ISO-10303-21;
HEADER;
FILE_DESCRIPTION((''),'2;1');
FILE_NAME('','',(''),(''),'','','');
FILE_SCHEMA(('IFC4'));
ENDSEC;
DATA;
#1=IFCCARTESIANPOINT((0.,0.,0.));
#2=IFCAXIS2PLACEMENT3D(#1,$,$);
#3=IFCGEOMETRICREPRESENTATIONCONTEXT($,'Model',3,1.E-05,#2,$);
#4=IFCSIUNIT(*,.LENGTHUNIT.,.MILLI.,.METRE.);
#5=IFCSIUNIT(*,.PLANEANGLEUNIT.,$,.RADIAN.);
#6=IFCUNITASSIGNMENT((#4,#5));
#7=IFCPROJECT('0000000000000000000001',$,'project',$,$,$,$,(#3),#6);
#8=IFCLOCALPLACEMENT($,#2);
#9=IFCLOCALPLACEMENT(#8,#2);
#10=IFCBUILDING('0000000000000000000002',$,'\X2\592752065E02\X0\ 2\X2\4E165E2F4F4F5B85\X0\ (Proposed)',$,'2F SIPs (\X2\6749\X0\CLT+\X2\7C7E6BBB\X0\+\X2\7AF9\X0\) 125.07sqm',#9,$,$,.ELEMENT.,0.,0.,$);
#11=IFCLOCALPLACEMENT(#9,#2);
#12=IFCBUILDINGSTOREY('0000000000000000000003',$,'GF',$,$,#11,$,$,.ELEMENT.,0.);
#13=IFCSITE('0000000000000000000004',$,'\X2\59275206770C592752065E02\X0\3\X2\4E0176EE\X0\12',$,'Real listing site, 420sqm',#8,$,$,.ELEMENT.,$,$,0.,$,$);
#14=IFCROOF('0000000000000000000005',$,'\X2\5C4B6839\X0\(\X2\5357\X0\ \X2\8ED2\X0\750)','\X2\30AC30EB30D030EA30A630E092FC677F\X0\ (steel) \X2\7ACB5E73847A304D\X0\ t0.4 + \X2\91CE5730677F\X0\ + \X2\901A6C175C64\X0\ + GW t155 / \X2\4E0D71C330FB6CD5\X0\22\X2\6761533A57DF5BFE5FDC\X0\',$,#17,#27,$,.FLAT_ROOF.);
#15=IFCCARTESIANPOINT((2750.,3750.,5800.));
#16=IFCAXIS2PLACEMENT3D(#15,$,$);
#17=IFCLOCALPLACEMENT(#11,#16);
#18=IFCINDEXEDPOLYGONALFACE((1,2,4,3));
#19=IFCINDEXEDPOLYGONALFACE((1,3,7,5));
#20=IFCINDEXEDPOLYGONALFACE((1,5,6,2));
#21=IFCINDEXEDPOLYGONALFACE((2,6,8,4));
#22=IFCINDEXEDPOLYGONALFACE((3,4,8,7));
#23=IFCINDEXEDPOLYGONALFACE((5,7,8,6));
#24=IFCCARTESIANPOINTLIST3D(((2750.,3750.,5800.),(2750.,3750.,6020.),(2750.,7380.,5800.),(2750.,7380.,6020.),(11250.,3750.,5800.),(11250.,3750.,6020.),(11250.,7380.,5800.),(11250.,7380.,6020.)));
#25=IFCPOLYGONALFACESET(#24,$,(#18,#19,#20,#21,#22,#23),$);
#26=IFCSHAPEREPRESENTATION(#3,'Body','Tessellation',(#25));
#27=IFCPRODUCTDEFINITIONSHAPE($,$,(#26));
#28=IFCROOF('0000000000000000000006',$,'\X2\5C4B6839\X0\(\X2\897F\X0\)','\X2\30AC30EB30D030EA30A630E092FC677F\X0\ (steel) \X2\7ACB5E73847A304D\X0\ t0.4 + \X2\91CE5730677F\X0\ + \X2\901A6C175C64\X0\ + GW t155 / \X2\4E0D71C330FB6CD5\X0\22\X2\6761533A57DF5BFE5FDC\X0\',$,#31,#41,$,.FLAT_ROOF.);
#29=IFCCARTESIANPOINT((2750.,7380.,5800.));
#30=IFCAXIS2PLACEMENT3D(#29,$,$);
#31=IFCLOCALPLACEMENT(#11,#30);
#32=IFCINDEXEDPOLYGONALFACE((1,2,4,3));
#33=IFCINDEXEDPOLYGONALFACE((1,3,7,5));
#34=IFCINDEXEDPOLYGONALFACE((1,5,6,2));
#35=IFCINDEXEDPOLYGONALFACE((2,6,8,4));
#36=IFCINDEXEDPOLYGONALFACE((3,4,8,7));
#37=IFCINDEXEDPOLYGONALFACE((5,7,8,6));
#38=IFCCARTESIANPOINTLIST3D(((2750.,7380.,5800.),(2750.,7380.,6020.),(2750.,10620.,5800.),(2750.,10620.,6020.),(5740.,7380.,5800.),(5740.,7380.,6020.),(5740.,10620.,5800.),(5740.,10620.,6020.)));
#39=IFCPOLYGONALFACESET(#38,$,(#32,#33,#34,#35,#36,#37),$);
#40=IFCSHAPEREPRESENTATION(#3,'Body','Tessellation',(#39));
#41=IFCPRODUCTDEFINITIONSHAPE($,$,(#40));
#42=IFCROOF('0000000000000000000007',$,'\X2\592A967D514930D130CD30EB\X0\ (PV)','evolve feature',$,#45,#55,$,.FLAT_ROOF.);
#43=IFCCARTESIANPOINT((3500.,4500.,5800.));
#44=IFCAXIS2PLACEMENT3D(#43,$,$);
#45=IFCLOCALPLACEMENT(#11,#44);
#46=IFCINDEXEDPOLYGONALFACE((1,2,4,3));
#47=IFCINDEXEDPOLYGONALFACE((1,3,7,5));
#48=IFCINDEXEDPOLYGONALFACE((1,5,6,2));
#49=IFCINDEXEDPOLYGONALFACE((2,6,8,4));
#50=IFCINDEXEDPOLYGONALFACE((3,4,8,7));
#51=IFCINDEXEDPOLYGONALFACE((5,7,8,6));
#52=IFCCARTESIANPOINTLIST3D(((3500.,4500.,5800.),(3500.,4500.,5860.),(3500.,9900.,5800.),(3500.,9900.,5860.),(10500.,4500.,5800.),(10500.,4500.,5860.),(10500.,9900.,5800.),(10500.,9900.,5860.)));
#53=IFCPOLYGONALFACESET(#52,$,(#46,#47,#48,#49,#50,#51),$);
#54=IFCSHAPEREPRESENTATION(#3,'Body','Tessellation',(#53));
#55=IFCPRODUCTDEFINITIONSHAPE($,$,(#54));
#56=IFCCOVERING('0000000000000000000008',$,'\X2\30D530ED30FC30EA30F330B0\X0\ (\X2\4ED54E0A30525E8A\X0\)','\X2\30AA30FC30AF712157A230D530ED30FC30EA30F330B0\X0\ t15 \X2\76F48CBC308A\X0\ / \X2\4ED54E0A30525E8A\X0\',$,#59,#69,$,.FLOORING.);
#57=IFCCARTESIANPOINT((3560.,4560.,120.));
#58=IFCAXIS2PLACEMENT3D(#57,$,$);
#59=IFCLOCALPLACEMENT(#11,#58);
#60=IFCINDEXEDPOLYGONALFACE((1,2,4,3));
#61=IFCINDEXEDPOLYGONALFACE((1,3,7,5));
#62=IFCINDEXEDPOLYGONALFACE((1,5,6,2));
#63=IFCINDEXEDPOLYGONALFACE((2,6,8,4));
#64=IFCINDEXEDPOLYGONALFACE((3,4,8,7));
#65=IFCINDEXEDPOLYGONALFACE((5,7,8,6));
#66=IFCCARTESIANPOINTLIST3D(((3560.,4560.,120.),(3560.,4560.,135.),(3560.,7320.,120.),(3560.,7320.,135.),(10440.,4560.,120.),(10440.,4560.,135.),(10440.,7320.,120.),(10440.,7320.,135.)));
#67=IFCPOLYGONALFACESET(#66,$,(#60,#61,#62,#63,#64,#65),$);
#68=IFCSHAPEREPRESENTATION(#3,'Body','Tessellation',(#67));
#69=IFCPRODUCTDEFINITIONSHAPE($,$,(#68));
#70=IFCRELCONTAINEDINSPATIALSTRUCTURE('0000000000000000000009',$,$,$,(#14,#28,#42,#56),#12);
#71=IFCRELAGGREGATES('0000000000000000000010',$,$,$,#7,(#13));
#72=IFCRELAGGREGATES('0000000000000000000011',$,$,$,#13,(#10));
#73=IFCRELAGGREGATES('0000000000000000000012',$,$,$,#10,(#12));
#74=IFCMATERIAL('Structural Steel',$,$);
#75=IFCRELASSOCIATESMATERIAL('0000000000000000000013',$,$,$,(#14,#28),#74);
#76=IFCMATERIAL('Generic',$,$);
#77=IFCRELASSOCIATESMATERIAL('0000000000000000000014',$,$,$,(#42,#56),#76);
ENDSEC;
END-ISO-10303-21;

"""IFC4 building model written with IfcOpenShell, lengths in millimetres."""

from ifc_helpers import new_model, si_unit, frame, frame_2d, origin, place, context, project, spatial, rectangle, extrude, material, element, save


model = new_model("IFC4")

# Units and contexts
model_context = context("Model", 3, precision=1e-05, world=origin())
ifc_project = project(units=[si_unit("LENGTHUNIT", "METRE", prefix="MILLI"), si_unit("PLANEANGLEUNIT", "RADIAN")], contexts=[model_context])

# Site, building, storey
site_placement = place(None, origin())
site = spatial("IfcSite", under=ifc_project, at=site_placement, Name="大分県大分市3丁目12", ObjectType="Real listing site, 420sqm", CompositionType="ELEMENT", RefElevation=0.0)
building_placement = place(site_placement, origin())
building = spatial("IfcBuilding", under=site, at=building_placement, Name="大分市 2世帯住宅 (Proposed)", ObjectType="2F SIPs (杉CLT+籾殻+竹) 125.07sqm", CompositionType="ELEMENT", ElevationOfRefHeight=0.0, ElevationOfTerrain=0.0)
storey_placement = place(building_placement, origin())
storey = spatial("IfcBuildingStorey", under=building, at=storey_placement, Name="GF", CompositionType="ELEMENT", Elevation=0.0)

# Shared definitions
ifc_material_1 = material(Name="Generic")

# Roofs
ifc_material_2 = material(Name="Structural Steel")
roof_1_placement = place(storey_placement, frame((2750.0, 3750.0, 5800.0)))
element("IfcRoof", 1, at=roof_1_placement, inside=storey, material=ifc_material_2, Name="屋根(南 軒750)", Description="ガルバリウム鋼板 (steel) 立平葺き t0.4 + 野地板 + 通気層 + GW t155 / 不燃・法22条区域対応", PredefinedType="FLAT_ROOF", context=model_context, shape_type="SweptSolid", body=[
    extrude(rectangle(XDim=8500.0, YDim=3630.0, at=frame_2d((4250.0, 1815.0))), frame((2750.0, 3750.0, 5800.0)), (0.0, 0.0, 1.0), 220.0),
])
roof_2_placement = place(storey_placement, frame((2750.0, 7380.0, 5800.0)))
element("IfcRoof", 2, at=roof_2_placement, inside=storey, material=ifc_material_2, Name="屋根(西)", Description="ガルバリウム鋼板 (steel) 立平葺き t0.4 + 野地板 + 通気層 + GW t155 / 不燃・法22条区域対応", PredefinedType="FLAT_ROOF", context=model_context, shape_type="SweptSolid", body=[
    extrude(rectangle(XDim=2990.0, YDim=3240.0, at=frame_2d((1495.0, 1620.0))), frame((2750.0, 7380.0, 5800.0)), (0.0, 0.0, 1.0), 220.0),
])
roof_3_placement = place(storey_placement, frame((3500.0, 4500.0, 5800.0)))
element("IfcRoof", 3, at=roof_3_placement, inside=storey, material=ifc_material_1, Name="太陽光パネル (PV)", Description="evolve feature", PredefinedType="FLAT_ROOF", context=model_context, shape_type="SweptSolid", body=[
    extrude(rectangle(XDim=7000.0, YDim=5400.0, at=frame_2d((3500.0, 2700.0))), frame((3500.0, 4500.0, 5800.0)), (0.0, 0.0, 1.0), 60.0),
])

# Covering
covering_placement = place(storey_placement, frame((3560.0, 4560.0, 120.0)))
element("IfcCovering", 4, at=covering_placement, inside=storey, material=ifc_material_1, Name="フローリング (仕上げ床)", Description="オーク無垢フローリング t15 直貼り / 仕上げ床", PredefinedType="FLOORING", context=model_context, shape_type="SweptSolid", body=[
    extrude(rectangle(XDim=6880.0, YDim=2760.0, at=frame_2d((3440.0, 1380.0))), frame((3560.0, 4560.0, 120.0)), (0.0, 0.0, 1.0), 15.0),
])

save(model, "model.ifc")
